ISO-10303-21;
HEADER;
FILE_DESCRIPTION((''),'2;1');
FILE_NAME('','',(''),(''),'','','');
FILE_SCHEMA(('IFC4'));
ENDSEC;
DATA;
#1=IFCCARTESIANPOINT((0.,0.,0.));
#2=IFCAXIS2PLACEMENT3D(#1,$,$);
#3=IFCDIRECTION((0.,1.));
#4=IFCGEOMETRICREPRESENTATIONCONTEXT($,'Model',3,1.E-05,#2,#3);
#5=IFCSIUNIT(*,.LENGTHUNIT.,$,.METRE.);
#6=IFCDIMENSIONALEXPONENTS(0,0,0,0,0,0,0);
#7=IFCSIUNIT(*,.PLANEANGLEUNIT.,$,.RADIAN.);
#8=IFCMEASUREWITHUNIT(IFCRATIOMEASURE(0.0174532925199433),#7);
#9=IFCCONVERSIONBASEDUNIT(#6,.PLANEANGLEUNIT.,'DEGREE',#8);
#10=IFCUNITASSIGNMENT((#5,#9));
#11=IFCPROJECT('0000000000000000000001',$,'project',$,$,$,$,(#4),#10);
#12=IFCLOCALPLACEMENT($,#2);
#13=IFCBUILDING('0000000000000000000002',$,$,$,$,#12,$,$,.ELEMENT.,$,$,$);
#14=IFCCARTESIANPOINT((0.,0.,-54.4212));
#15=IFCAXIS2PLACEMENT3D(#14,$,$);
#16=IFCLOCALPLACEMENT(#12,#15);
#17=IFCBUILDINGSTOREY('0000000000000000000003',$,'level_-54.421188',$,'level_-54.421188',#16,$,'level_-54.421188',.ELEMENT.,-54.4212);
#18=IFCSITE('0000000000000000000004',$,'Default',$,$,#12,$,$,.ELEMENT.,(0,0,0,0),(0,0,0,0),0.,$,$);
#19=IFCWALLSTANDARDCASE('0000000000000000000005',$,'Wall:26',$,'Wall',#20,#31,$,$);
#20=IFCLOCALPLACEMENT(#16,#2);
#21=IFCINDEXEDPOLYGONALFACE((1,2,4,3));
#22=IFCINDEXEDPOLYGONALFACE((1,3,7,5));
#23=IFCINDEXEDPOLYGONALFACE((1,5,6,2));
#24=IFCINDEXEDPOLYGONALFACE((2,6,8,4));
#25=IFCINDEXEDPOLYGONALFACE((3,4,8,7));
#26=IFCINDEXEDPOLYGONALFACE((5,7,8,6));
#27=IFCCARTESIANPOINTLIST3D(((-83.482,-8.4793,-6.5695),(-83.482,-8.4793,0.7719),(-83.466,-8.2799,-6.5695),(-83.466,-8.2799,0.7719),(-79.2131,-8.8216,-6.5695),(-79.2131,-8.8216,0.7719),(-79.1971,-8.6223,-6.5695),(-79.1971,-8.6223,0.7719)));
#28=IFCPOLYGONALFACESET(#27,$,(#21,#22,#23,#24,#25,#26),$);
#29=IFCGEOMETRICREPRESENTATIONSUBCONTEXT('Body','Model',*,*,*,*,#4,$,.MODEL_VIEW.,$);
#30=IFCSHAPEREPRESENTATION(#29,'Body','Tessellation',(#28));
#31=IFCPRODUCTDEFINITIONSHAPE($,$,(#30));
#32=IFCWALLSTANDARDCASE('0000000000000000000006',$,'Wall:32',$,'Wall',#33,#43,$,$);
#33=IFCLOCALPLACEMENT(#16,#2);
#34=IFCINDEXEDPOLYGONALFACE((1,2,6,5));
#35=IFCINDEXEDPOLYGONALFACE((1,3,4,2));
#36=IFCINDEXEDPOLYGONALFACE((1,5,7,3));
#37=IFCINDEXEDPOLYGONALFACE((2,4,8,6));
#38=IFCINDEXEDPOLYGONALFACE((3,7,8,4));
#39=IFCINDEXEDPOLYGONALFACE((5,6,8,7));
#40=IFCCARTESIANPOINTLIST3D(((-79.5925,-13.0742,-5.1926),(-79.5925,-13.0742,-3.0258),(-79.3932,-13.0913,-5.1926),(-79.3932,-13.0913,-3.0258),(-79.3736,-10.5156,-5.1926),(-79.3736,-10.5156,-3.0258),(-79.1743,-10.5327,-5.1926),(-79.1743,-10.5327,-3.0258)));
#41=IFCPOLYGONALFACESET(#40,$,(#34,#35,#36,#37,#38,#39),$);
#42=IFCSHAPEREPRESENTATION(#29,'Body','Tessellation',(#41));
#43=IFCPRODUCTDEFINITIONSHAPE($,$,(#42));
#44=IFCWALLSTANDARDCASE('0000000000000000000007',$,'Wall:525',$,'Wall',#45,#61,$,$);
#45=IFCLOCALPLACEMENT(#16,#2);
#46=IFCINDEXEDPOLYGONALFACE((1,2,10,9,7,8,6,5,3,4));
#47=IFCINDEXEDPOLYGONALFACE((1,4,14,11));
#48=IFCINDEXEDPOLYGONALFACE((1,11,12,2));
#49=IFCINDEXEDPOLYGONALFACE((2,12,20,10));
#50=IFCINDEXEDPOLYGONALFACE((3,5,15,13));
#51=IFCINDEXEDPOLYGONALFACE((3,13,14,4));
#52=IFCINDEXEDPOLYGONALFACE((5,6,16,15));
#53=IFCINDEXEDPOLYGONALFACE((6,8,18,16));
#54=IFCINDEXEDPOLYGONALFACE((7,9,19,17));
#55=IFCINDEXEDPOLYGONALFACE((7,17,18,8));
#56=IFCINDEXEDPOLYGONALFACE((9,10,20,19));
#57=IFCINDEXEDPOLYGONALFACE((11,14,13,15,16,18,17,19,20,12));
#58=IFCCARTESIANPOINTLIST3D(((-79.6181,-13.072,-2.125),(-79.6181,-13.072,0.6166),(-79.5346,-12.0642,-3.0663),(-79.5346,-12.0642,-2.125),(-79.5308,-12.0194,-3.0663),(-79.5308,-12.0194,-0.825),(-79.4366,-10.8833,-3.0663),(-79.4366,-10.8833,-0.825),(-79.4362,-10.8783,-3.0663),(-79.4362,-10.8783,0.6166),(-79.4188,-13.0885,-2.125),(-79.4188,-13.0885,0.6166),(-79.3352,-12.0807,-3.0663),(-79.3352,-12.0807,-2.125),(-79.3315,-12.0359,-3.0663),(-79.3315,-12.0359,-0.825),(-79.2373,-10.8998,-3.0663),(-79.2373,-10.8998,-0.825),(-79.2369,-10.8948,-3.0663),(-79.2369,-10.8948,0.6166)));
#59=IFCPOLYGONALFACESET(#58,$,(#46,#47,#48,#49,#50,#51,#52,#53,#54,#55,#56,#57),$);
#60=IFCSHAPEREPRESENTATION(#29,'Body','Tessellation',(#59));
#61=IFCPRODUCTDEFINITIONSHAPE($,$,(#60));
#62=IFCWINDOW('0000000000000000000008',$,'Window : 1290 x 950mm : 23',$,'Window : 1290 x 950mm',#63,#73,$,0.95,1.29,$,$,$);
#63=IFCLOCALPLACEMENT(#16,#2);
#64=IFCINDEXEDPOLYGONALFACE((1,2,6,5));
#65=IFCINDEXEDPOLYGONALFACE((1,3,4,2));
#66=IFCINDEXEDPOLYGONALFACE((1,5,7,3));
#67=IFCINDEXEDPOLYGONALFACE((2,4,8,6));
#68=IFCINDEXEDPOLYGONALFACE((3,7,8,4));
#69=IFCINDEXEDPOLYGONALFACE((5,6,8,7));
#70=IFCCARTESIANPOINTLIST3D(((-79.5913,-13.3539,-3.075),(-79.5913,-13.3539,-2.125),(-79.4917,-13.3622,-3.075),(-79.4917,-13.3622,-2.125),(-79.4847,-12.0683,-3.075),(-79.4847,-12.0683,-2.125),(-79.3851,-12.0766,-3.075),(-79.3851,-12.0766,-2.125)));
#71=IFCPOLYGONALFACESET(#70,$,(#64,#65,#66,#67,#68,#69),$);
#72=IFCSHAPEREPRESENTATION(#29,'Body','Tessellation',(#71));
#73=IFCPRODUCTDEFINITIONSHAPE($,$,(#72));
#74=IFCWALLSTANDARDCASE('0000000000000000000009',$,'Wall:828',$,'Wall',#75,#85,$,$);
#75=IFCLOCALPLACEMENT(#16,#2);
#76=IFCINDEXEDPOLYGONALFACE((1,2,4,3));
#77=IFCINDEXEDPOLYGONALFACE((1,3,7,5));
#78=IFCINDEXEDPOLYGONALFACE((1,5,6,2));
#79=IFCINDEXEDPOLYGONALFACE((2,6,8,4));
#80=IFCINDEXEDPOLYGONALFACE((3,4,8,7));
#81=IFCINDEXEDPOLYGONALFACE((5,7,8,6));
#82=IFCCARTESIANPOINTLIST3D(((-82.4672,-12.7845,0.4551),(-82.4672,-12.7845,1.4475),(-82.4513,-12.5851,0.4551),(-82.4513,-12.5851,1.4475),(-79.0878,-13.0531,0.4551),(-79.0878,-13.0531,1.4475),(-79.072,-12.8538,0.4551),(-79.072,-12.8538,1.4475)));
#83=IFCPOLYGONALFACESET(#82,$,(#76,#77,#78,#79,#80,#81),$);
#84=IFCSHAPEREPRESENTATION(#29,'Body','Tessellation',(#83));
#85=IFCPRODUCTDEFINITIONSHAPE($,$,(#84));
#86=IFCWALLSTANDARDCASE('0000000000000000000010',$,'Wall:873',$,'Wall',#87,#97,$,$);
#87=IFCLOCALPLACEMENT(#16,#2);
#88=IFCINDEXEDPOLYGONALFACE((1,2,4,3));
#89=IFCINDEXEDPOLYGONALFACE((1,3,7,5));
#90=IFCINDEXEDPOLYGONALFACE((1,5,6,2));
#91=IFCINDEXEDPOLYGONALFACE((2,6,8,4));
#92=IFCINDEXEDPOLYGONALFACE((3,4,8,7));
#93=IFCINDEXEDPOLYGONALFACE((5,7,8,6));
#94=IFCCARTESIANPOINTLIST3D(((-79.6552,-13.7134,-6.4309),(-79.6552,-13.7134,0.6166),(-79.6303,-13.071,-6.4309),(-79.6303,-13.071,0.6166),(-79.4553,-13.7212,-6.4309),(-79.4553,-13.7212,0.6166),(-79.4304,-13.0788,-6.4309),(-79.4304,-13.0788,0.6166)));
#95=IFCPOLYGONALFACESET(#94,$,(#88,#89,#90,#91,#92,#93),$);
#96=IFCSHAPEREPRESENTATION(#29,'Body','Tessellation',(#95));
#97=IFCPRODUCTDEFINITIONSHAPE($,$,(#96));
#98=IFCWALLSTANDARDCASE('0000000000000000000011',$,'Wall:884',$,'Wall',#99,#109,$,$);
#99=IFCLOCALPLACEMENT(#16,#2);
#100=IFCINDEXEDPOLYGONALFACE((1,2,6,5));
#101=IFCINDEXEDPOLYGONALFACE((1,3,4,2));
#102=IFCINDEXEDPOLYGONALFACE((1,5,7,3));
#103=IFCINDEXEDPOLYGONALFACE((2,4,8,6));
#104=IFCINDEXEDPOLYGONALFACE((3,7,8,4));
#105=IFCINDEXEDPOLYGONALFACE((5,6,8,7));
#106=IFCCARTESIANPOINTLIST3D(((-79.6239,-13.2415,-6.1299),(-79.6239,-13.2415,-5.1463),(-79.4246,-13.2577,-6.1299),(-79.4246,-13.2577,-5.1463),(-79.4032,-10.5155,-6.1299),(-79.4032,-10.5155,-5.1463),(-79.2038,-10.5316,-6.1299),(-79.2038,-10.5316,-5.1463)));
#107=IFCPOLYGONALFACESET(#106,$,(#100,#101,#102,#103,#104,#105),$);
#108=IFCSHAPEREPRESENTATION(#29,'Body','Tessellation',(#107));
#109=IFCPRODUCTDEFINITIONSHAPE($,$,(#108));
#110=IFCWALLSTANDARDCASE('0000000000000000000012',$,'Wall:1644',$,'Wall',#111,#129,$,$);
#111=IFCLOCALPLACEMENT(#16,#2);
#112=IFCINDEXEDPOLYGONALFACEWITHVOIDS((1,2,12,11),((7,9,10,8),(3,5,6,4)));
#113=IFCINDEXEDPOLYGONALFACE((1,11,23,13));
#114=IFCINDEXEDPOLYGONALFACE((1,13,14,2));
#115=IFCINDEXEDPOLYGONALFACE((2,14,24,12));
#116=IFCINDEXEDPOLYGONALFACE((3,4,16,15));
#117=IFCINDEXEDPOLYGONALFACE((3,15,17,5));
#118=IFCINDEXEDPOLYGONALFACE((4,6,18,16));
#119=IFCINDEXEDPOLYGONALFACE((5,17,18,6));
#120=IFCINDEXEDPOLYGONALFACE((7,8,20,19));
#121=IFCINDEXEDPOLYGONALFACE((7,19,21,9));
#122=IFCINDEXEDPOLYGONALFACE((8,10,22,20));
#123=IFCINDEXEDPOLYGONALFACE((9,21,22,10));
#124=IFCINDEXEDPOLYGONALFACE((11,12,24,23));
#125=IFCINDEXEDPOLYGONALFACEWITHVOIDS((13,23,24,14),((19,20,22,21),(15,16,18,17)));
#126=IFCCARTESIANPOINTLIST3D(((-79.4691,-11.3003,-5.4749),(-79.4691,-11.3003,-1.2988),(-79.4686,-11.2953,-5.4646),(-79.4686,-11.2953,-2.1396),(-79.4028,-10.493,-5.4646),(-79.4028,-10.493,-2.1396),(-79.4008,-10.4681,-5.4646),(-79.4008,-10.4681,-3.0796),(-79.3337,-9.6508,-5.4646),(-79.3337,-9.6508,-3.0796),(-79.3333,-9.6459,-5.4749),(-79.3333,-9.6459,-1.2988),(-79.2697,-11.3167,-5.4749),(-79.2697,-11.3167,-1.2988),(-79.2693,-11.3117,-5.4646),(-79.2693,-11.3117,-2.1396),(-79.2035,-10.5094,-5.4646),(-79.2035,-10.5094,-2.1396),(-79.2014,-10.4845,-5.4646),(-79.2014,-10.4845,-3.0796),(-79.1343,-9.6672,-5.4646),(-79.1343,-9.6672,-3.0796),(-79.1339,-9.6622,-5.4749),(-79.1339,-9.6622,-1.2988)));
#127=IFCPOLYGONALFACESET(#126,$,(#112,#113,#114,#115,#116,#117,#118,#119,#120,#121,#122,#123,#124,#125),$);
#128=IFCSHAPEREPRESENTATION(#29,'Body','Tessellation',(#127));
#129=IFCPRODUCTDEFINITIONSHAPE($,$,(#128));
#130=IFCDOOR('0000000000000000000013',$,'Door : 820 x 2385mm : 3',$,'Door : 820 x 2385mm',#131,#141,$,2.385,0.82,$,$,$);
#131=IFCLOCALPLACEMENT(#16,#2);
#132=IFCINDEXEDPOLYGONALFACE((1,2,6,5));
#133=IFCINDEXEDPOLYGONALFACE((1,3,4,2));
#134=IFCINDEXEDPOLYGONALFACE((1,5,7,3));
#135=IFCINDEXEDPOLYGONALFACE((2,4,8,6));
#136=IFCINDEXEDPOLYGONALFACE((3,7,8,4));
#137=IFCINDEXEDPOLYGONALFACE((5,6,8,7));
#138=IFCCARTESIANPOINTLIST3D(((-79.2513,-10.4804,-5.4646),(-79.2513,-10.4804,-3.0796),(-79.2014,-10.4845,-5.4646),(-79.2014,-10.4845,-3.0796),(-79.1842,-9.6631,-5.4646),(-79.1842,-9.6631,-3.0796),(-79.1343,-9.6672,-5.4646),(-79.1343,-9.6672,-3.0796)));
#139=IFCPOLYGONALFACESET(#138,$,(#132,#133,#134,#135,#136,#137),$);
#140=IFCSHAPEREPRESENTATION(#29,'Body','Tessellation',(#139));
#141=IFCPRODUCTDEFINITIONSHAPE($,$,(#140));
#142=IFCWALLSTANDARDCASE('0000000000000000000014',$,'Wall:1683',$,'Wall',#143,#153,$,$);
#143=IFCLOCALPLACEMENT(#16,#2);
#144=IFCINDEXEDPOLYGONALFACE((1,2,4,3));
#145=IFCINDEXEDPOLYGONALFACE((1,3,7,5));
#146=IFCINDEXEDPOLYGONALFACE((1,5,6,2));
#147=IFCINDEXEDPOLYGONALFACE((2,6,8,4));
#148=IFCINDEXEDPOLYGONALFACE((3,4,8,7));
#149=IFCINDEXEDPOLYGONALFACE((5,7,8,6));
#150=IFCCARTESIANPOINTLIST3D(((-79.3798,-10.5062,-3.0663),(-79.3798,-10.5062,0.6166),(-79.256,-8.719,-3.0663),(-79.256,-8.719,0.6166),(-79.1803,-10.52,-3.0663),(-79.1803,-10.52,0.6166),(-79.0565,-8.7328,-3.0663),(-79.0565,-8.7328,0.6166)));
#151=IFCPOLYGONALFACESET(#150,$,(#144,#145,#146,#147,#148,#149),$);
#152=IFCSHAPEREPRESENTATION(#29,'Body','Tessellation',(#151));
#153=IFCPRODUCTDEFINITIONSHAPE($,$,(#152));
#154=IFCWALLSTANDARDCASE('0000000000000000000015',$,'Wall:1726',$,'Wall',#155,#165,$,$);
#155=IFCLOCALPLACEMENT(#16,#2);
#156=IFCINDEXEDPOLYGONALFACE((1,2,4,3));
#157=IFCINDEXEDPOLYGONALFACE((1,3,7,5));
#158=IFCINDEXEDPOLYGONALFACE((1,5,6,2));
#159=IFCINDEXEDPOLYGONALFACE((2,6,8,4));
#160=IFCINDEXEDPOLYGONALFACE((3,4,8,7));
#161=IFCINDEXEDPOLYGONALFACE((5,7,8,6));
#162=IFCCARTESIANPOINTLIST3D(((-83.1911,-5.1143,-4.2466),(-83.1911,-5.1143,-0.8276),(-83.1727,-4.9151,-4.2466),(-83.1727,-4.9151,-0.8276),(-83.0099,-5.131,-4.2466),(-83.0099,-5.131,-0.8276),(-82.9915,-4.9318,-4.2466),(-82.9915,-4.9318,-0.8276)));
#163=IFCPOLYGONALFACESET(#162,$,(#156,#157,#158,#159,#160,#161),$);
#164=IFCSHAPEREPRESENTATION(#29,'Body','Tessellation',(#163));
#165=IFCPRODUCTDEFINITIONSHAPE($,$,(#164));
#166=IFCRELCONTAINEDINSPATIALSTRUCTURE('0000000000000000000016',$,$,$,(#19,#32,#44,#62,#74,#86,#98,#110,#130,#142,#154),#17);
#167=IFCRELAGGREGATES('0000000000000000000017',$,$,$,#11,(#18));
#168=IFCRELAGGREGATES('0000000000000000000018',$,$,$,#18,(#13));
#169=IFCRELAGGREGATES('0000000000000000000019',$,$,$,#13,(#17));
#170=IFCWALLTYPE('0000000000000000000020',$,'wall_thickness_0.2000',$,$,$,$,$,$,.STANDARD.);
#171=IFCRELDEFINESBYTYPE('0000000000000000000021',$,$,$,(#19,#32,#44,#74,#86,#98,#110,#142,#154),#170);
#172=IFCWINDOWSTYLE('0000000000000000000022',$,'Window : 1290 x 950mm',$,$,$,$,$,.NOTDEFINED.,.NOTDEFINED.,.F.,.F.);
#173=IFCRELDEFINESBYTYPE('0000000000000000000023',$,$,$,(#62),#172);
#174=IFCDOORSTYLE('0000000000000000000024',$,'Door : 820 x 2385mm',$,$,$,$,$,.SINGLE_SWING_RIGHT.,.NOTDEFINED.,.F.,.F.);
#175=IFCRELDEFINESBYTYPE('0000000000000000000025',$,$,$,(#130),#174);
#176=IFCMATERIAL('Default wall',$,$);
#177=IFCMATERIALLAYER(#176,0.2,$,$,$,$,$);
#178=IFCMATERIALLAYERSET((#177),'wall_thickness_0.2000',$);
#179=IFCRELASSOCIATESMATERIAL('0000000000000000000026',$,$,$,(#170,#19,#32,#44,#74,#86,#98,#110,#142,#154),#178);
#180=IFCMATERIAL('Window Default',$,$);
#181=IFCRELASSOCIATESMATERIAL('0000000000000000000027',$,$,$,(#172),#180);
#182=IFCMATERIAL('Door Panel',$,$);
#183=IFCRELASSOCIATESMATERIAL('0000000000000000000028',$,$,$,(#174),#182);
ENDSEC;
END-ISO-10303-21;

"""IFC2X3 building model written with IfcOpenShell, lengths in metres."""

from ifc_helpers import new_model, entity, si_unit, converted_unit, direction, frame, frame_2d, origin, origin_2d_with_axis, place, context, subcontext, project, spatial, polyline, rectangle, outline, extrude, source, transform, mapped, material, layer, layer_set, layer_usage, type_object, type_shapes, element, fill, save


model = new_model("IFC2X3")

# Units and contexts
model_context = context("Model", 3, precision=1e-05, world=origin(), true_north=direction((0.0, 1.0)))
body_context = subcontext(model_context, "Body", "Model", "MODEL_VIEW")
ifc_project = project(units=[si_unit("LENGTHUNIT", "METRE"), converted_unit("PLANEANGLEUNIT", "DEGREE", entity("IfcRatioMeasure", 0.0174532925199433), si_unit("PLANEANGLEUNIT", "RADIAN"), dimensions=[0, 0, 0, 0, 0, 0, 0])], contexts=[model_context])

# Site, building, storey
placement_1 = place(None, origin())
site = spatial("IfcSite", under=ifc_project, at=placement_1, Name="Default", CompositionType="ELEMENT", RefLatitude=(0, 0, 0, 0), RefLongitude=(0, 0, 0, 0), RefElevation=0.0)
building = spatial("IfcBuilding", under=site, at=placement_1, CompositionType="ELEMENT")
storey_placement = place(placement_1, frame((0.0, 0.0, -54.4212)))
storey = spatial("IfcBuildingStorey", under=building, at=storey_placement, Name="level_-54.421188", ObjectType="level_-54.421188", LongName="level_-54.421188", CompositionType="ELEMENT", Elevation=-54.4212)

# Walls
ifc_material_1 = material(Name="Default wall")
ifc_layer = layer(ifc_material_1, 0.2)
ifc_layer_set = layer_set([ifc_layer], Name="wall_thickness_0.2000")
ifc_layer_usage = layer_usage(ifc_layer_set, "AXIS2", "POSITIVE", -0.1)
wall_type = type_object("IfcWallType", Name="wall_thickness_0.2000", PredefinedType="STANDARD", material=ifc_layer_set)
placement_2 = place(placement_1, frame((0.0, 0.0, -60.9907)))
wall_1_placement = place(placement_2, frame((-79.2051, -8.7219, 0.0), z_axis=(0.0, 0.0, 1.0), x_axis=(-0.9968, 0.079934, 0.0)))
element("IfcWallStandardCase", 1, at=wall_1_placement, inside=storey, type_object=wall_type, material=ifc_layer_usage, Name="Wall:26", ObjectType="Wall", context=body_context, shape_type="SweptSolid", body=[
    extrude(outline(polyline([(4.2826, -0.1), (4.2826, 0.1), (0.0, 0.1), (0.0, -0.1), (4.2826, -0.1)])), origin(), (0.0, 0.0, 1.0), 7.3414),
])
placement_3 = place(placement_1, frame((0.0, 0.0, -59.6138)))
wall_2_placement = place(placement_3, frame((-79.274, -10.5242, 0.0), z_axis=(0.0, 0.0, 1.0), x_axis=(-0.085244, -0.99636, 0.0)))
element("IfcWallStandardCase", 2, at=wall_2_placement, inside=storey, type_object=wall_type, material=ifc_layer_usage, Name="Wall:32", ObjectType="Wall", context=body_context, shape_type="SweptSolid", body=[
    extrude(outline(polyline([(2.5679, -0.1), (2.5679, 0.1), (0.0, 0.1), (0.0, -0.1), (2.5679, -0.1)])), origin(), (0.0, 0.0, 1.0), 2.1668),
])

# Wall, openings, window
placement_4 = place(placement_1, frame((0.0, 0.0, -57.4875)))
wall_3_placement = place(placement_4, frame((-79.3366, -10.8865, 0.0), z_axis=(0.0, 0.0, 1.0), x_axis=(-0.082631, -0.99658, 0.0)))
wall_3 = element("IfcWallStandardCase", 3, at=wall_3_placement, inside=storey, type_object=wall_type, material=ifc_layer_usage, Name="Wall:525", ObjectType="Wall", context=body_context, shape_type="SweptSolid", body=[
    extrude(outline(polyline([(2.2013, -0.1), (2.2013, 0.1), (0.0, 0.1), (0.0, -0.1), (2.2013, -0.1)])), origin(), (0.0, 0.0, 1.0), 3.6829),
])
opening_1_placement = place(wall_3_placement, frame((0.005, -0.1, -1.0837)))
element("IfcOpeningElement", 4, at=opening_1_placement, cuts=wall_3, ObjectType="Opening", context=body_context, shape_type="SweptSolid", body=[
    extrude(rectangle(XDim=1.14, YDim=3.325, at=frame_2d((1.6625, 0.57), x_axis=(0.0, 1.0))), frame((0.0, 0.0, 0.0), z_axis=(0.0, 1.0, 0.0), x_axis=(0.0, 0.0, 1.0)), (0.0, 0.0, 1.0), 0.2),
])
opening_2_placement = place(wall_3_placement, frame((1.19, -0.1, -0.0087)))
opening_2 = element("IfcOpeningElement", 5, at=opening_2_placement, cuts=wall_3, ObjectType="Opening", context=body_context, shape_type="SweptSolid", body=[
    extrude(rectangle(XDim=1.29, YDim=0.95, at=frame_2d((0.475, 0.645), x_axis=(0.0, 1.0))), frame((0.0, 0.0, 0.0), z_axis=(0.0, 1.0, 0.0), x_axis=(0.0, 0.0, 1.0)), (0.0, 0.0, 1.0), 0.2),
])
ifc_material_2 = material(Name="Window Default")
window_style_1 = type_object("IfcWindowStyle", Name="Window : 1290 x 950mm", ConstructionType="NOTDEFINED", OperationType="NOTDEFINED", ParameterTakesPrecedence=False, Sizeable=False, material=ifc_material_2)
shared_shape_1 = source(origin(), body_context, "Body", "SweptSolid", [
    extrude(rectangle(XDim=0.1, YDim=1.29, at=origin_2d_with_axis()), frame((0.645, 0.1, 0.0), z_axis=(0.0, 0.0, 1.0), x_axis=(0.0, 1.0, 0.0)), (0.0, 0.0, 1.0), 0.95),
])
type_shapes(window_style_1, [shared_shape_1])
window_1_placement = place(opening_2_placement, origin())
window_1 = element("IfcWindow", 6, at=window_1_placement, inside=storey, type_object=window_style_1, Name="Window : 1290 x 950mm : 23", ObjectType="Window : 1290 x 950mm", OverallHeight=0.95, OverallWidth=1.29, context=body_context, shape_type="MappedRepresentation", body=[
    mapped(shared_shape_1, transform((0.0, 0.0, 0.0), scale=1.0)),
])
fill(opening_2, window_1)

# Walls
placement_5 = place(placement_1, frame((0.0, 0.0, -53.9661)))
wall_4_placement = place(placement_5, frame((-82.4593, -12.6848, 0.0), z_axis=(0.0, 0.0, 1.0), x_axis=(0.996855, -0.07925, 0.0)))
element("IfcWallStandardCase", 7, at=wall_4_placement, inside=storey, type_object=wall_type, material=ifc_layer_usage, Name="Wall:828", ObjectType="Wall", context=body_context, shape_type="SweptSolid", body=[
    extrude(outline(polyline([(3.39, -0.1), (3.39, 0.1), (0.0, 0.1), (0.0, -0.1), (3.39, -0.1)])), origin(), (0.0, 0.0, 1.0), 0.9925),
])
placement_6 = place(placement_1, frame((0.0, 0.0, -60.8521)))
wall_5_placement = place(placement_6, frame((-79.5304, -13.0749, 0.0), z_axis=(0.0, 0.0, 1.0), x_axis=(-0.038733, -0.99925, 0.0)))
element("IfcWallStandardCase", 8, at=wall_5_placement, inside=storey, type_object=wall_type, material=ifc_layer_usage, Name="Wall:873", ObjectType="Wall", context=body_context, shape_type="SweptSolid", body=[
    extrude(outline(polyline([(0.6429, -0.1), (0.6429, 0.1), (0.0, 0.1), (0.0, -0.1), (0.6429, -0.1)])), origin(), (0.0, 0.0, 1.0), 7.0475),
])
placement_7 = place(placement_1, frame((0.0, 0.0, -60.5511)))
wall_6_placement = place(placement_7, frame((-79.3035, -10.5235, 0.0), z_axis=(0.0, 0.0, 1.0), x_axis=(-0.080715, -0.996737, 0.0)))
element("IfcWallStandardCase", 9, at=wall_6_placement, inside=storey, type_object=wall_type, material=ifc_layer_usage, Name="Wall:884", ObjectType="Wall", context=body_context, shape_type="SweptSolid", body=[
    extrude(outline(polyline([(2.735, -0.1), (2.735, 0.1), (0.0, 0.1), (0.0, -0.1), (2.735, -0.1)])), origin(), (0.0, 0.0, 1.0), 0.9836),
])

# Wall, openings, door
placement_8 = place(placement_1, frame((0.0, 0.0, -59.8961)))
wall_7_placement = place(placement_8, frame((-79.2336, -9.654, 0.0), z_axis=(0.0, 0.0, 1.0), x_axis=(-0.0818, -0.996649, 0.0)))
wall_7 = element("IfcWallStandardCase", 10, at=wall_7_placement, inside=storey, type_object=wall_type, material=ifc_layer_usage, Name="Wall:1644", ObjectType="Wall", context=body_context, shape_type="SweptSolid", body=[
    extrude(outline(polyline([(1.66, -0.1), (1.66, 0.1), (0.0, 0.1), (0.0, -0.1), (1.66, -0.1)])), origin(), (0.0, 0.0, 1.0), 4.1761),
])
opening_3_placement = place(wall_7_placement, frame((0.005, -0.1, 0.0103)))
opening_3 = element("IfcOpeningElement", 11, at=opening_3_placement, cuts=wall_7, ObjectType="Opening", context=body_context, shape_type="SweptSolid", body=[
    extrude(rectangle(XDim=0.82, YDim=2.385, at=frame_2d((1.1925, 0.41), x_axis=(0.0, 1.0))), frame((0.0, 0.0, 0.0), z_axis=(0.0, 1.0, 0.0), x_axis=(0.0, 0.0, 1.0)), (0.0, 0.0, 1.0), 0.2),
])
opening_4_placement = place(wall_7_placement, frame((0.85, -0.1, 0.0103)))
element("IfcOpeningElement", 12, at=opening_4_placement, cuts=wall_7, ObjectType="Opening", context=body_context, shape_type="SweptSolid", body=[
    extrude(rectangle(XDim=0.805, YDim=3.325, at=frame_2d((1.6625, 0.4025), x_axis=(0.0, 1.0))), frame((0.0, 0.0, 0.0), z_axis=(0.0, 1.0, 0.0), x_axis=(0.0, 0.0, 1.0)), (0.0, 0.0, 1.0), 0.2),
])
ifc_material_3 = material(Name="Door Panel")
door_style_1 = type_object("IfcDoorStyle", Name="Door : 820 x 2385mm", ConstructionType="NOTDEFINED", OperationType="SINGLE_SWING_RIGHT", ParameterTakesPrecedence=False, Sizeable=False, material=ifc_material_3)
shared_shape_2 = source(origin(), body_context, "Body", "SweptSolid", [
    extrude(rectangle(XDim=0.05, YDim=0.82, at=origin_2d_with_axis()), frame((0.41, 0.175, 0.0), z_axis=(0.0, 0.0, 1.0), x_axis=(0.0, 1.0, 0.0)), (0.0, 0.0, 1.0), 2.385),
])
type_shapes(door_style_1, [shared_shape_2])
door_1_placement = place(opening_3_placement, origin())
door_1 = element("IfcDoor", 13, at=door_1_placement, inside=storey, type_object=door_style_1, Name="Door : 820 x 2385mm : 3", ObjectType="Door : 820 x 2385mm", OverallHeight=2.385, OverallWidth=0.82, context=body_context, shape_type="MappedRepresentation", body=[
    mapped(shared_shape_2, transform((0.0, 0.0, 0.0), scale=1.0)),
])
fill(opening_3, door_1)

# Walls
placement_9 = place(placement_1, frame((0.0, 0.0, -57.4875)))
wall_8_placement = place(placement_9, frame((-79.1563, -8.7259, 0.0), z_axis=(0.0, 0.0, 1.0), x_axis=(-0.069108, -0.997609, 0.0)))
element("IfcWallStandardCase", 14, at=wall_8_placement, inside=storey, type_object=wall_type, material=ifc_layer_usage, Name="Wall:1683", ObjectType="Wall", context=body_context, shape_type="SweptSolid", body=[
    extrude(outline(polyline([(1.7915, -0.1), (1.7915, 0.1), (0.0, 0.1), (0.0, -0.1), (1.7915, -0.1)])), origin(), (0.0, 0.0, 1.0), 3.6829),
])
placement_10 = place(placement_1, frame((0.0, 0.0, -58.6678)))
wall_9_placement = place(placement_10, frame((-83.0007, -5.0314, 0.0), z_axis=(0.0, 0.0, 1.0), x_axis=(-0.995771, 0.091868, 0.0)))
element("IfcWallStandardCase", 15, at=wall_9_placement, inside=storey, type_object=wall_type, material=ifc_layer_usage, Name="Wall:1726", ObjectType="Wall", context=body_context, shape_type="SweptSolid", body=[
    extrude(outline(polyline([(0.182, -0.1), (0.182, 0.1), (0.0, 0.1), (0.0, -0.1), (0.182, -0.1)])), origin(), (0.0, 0.0, 1.0), 3.419),
])

save(model, "model.ifc")
